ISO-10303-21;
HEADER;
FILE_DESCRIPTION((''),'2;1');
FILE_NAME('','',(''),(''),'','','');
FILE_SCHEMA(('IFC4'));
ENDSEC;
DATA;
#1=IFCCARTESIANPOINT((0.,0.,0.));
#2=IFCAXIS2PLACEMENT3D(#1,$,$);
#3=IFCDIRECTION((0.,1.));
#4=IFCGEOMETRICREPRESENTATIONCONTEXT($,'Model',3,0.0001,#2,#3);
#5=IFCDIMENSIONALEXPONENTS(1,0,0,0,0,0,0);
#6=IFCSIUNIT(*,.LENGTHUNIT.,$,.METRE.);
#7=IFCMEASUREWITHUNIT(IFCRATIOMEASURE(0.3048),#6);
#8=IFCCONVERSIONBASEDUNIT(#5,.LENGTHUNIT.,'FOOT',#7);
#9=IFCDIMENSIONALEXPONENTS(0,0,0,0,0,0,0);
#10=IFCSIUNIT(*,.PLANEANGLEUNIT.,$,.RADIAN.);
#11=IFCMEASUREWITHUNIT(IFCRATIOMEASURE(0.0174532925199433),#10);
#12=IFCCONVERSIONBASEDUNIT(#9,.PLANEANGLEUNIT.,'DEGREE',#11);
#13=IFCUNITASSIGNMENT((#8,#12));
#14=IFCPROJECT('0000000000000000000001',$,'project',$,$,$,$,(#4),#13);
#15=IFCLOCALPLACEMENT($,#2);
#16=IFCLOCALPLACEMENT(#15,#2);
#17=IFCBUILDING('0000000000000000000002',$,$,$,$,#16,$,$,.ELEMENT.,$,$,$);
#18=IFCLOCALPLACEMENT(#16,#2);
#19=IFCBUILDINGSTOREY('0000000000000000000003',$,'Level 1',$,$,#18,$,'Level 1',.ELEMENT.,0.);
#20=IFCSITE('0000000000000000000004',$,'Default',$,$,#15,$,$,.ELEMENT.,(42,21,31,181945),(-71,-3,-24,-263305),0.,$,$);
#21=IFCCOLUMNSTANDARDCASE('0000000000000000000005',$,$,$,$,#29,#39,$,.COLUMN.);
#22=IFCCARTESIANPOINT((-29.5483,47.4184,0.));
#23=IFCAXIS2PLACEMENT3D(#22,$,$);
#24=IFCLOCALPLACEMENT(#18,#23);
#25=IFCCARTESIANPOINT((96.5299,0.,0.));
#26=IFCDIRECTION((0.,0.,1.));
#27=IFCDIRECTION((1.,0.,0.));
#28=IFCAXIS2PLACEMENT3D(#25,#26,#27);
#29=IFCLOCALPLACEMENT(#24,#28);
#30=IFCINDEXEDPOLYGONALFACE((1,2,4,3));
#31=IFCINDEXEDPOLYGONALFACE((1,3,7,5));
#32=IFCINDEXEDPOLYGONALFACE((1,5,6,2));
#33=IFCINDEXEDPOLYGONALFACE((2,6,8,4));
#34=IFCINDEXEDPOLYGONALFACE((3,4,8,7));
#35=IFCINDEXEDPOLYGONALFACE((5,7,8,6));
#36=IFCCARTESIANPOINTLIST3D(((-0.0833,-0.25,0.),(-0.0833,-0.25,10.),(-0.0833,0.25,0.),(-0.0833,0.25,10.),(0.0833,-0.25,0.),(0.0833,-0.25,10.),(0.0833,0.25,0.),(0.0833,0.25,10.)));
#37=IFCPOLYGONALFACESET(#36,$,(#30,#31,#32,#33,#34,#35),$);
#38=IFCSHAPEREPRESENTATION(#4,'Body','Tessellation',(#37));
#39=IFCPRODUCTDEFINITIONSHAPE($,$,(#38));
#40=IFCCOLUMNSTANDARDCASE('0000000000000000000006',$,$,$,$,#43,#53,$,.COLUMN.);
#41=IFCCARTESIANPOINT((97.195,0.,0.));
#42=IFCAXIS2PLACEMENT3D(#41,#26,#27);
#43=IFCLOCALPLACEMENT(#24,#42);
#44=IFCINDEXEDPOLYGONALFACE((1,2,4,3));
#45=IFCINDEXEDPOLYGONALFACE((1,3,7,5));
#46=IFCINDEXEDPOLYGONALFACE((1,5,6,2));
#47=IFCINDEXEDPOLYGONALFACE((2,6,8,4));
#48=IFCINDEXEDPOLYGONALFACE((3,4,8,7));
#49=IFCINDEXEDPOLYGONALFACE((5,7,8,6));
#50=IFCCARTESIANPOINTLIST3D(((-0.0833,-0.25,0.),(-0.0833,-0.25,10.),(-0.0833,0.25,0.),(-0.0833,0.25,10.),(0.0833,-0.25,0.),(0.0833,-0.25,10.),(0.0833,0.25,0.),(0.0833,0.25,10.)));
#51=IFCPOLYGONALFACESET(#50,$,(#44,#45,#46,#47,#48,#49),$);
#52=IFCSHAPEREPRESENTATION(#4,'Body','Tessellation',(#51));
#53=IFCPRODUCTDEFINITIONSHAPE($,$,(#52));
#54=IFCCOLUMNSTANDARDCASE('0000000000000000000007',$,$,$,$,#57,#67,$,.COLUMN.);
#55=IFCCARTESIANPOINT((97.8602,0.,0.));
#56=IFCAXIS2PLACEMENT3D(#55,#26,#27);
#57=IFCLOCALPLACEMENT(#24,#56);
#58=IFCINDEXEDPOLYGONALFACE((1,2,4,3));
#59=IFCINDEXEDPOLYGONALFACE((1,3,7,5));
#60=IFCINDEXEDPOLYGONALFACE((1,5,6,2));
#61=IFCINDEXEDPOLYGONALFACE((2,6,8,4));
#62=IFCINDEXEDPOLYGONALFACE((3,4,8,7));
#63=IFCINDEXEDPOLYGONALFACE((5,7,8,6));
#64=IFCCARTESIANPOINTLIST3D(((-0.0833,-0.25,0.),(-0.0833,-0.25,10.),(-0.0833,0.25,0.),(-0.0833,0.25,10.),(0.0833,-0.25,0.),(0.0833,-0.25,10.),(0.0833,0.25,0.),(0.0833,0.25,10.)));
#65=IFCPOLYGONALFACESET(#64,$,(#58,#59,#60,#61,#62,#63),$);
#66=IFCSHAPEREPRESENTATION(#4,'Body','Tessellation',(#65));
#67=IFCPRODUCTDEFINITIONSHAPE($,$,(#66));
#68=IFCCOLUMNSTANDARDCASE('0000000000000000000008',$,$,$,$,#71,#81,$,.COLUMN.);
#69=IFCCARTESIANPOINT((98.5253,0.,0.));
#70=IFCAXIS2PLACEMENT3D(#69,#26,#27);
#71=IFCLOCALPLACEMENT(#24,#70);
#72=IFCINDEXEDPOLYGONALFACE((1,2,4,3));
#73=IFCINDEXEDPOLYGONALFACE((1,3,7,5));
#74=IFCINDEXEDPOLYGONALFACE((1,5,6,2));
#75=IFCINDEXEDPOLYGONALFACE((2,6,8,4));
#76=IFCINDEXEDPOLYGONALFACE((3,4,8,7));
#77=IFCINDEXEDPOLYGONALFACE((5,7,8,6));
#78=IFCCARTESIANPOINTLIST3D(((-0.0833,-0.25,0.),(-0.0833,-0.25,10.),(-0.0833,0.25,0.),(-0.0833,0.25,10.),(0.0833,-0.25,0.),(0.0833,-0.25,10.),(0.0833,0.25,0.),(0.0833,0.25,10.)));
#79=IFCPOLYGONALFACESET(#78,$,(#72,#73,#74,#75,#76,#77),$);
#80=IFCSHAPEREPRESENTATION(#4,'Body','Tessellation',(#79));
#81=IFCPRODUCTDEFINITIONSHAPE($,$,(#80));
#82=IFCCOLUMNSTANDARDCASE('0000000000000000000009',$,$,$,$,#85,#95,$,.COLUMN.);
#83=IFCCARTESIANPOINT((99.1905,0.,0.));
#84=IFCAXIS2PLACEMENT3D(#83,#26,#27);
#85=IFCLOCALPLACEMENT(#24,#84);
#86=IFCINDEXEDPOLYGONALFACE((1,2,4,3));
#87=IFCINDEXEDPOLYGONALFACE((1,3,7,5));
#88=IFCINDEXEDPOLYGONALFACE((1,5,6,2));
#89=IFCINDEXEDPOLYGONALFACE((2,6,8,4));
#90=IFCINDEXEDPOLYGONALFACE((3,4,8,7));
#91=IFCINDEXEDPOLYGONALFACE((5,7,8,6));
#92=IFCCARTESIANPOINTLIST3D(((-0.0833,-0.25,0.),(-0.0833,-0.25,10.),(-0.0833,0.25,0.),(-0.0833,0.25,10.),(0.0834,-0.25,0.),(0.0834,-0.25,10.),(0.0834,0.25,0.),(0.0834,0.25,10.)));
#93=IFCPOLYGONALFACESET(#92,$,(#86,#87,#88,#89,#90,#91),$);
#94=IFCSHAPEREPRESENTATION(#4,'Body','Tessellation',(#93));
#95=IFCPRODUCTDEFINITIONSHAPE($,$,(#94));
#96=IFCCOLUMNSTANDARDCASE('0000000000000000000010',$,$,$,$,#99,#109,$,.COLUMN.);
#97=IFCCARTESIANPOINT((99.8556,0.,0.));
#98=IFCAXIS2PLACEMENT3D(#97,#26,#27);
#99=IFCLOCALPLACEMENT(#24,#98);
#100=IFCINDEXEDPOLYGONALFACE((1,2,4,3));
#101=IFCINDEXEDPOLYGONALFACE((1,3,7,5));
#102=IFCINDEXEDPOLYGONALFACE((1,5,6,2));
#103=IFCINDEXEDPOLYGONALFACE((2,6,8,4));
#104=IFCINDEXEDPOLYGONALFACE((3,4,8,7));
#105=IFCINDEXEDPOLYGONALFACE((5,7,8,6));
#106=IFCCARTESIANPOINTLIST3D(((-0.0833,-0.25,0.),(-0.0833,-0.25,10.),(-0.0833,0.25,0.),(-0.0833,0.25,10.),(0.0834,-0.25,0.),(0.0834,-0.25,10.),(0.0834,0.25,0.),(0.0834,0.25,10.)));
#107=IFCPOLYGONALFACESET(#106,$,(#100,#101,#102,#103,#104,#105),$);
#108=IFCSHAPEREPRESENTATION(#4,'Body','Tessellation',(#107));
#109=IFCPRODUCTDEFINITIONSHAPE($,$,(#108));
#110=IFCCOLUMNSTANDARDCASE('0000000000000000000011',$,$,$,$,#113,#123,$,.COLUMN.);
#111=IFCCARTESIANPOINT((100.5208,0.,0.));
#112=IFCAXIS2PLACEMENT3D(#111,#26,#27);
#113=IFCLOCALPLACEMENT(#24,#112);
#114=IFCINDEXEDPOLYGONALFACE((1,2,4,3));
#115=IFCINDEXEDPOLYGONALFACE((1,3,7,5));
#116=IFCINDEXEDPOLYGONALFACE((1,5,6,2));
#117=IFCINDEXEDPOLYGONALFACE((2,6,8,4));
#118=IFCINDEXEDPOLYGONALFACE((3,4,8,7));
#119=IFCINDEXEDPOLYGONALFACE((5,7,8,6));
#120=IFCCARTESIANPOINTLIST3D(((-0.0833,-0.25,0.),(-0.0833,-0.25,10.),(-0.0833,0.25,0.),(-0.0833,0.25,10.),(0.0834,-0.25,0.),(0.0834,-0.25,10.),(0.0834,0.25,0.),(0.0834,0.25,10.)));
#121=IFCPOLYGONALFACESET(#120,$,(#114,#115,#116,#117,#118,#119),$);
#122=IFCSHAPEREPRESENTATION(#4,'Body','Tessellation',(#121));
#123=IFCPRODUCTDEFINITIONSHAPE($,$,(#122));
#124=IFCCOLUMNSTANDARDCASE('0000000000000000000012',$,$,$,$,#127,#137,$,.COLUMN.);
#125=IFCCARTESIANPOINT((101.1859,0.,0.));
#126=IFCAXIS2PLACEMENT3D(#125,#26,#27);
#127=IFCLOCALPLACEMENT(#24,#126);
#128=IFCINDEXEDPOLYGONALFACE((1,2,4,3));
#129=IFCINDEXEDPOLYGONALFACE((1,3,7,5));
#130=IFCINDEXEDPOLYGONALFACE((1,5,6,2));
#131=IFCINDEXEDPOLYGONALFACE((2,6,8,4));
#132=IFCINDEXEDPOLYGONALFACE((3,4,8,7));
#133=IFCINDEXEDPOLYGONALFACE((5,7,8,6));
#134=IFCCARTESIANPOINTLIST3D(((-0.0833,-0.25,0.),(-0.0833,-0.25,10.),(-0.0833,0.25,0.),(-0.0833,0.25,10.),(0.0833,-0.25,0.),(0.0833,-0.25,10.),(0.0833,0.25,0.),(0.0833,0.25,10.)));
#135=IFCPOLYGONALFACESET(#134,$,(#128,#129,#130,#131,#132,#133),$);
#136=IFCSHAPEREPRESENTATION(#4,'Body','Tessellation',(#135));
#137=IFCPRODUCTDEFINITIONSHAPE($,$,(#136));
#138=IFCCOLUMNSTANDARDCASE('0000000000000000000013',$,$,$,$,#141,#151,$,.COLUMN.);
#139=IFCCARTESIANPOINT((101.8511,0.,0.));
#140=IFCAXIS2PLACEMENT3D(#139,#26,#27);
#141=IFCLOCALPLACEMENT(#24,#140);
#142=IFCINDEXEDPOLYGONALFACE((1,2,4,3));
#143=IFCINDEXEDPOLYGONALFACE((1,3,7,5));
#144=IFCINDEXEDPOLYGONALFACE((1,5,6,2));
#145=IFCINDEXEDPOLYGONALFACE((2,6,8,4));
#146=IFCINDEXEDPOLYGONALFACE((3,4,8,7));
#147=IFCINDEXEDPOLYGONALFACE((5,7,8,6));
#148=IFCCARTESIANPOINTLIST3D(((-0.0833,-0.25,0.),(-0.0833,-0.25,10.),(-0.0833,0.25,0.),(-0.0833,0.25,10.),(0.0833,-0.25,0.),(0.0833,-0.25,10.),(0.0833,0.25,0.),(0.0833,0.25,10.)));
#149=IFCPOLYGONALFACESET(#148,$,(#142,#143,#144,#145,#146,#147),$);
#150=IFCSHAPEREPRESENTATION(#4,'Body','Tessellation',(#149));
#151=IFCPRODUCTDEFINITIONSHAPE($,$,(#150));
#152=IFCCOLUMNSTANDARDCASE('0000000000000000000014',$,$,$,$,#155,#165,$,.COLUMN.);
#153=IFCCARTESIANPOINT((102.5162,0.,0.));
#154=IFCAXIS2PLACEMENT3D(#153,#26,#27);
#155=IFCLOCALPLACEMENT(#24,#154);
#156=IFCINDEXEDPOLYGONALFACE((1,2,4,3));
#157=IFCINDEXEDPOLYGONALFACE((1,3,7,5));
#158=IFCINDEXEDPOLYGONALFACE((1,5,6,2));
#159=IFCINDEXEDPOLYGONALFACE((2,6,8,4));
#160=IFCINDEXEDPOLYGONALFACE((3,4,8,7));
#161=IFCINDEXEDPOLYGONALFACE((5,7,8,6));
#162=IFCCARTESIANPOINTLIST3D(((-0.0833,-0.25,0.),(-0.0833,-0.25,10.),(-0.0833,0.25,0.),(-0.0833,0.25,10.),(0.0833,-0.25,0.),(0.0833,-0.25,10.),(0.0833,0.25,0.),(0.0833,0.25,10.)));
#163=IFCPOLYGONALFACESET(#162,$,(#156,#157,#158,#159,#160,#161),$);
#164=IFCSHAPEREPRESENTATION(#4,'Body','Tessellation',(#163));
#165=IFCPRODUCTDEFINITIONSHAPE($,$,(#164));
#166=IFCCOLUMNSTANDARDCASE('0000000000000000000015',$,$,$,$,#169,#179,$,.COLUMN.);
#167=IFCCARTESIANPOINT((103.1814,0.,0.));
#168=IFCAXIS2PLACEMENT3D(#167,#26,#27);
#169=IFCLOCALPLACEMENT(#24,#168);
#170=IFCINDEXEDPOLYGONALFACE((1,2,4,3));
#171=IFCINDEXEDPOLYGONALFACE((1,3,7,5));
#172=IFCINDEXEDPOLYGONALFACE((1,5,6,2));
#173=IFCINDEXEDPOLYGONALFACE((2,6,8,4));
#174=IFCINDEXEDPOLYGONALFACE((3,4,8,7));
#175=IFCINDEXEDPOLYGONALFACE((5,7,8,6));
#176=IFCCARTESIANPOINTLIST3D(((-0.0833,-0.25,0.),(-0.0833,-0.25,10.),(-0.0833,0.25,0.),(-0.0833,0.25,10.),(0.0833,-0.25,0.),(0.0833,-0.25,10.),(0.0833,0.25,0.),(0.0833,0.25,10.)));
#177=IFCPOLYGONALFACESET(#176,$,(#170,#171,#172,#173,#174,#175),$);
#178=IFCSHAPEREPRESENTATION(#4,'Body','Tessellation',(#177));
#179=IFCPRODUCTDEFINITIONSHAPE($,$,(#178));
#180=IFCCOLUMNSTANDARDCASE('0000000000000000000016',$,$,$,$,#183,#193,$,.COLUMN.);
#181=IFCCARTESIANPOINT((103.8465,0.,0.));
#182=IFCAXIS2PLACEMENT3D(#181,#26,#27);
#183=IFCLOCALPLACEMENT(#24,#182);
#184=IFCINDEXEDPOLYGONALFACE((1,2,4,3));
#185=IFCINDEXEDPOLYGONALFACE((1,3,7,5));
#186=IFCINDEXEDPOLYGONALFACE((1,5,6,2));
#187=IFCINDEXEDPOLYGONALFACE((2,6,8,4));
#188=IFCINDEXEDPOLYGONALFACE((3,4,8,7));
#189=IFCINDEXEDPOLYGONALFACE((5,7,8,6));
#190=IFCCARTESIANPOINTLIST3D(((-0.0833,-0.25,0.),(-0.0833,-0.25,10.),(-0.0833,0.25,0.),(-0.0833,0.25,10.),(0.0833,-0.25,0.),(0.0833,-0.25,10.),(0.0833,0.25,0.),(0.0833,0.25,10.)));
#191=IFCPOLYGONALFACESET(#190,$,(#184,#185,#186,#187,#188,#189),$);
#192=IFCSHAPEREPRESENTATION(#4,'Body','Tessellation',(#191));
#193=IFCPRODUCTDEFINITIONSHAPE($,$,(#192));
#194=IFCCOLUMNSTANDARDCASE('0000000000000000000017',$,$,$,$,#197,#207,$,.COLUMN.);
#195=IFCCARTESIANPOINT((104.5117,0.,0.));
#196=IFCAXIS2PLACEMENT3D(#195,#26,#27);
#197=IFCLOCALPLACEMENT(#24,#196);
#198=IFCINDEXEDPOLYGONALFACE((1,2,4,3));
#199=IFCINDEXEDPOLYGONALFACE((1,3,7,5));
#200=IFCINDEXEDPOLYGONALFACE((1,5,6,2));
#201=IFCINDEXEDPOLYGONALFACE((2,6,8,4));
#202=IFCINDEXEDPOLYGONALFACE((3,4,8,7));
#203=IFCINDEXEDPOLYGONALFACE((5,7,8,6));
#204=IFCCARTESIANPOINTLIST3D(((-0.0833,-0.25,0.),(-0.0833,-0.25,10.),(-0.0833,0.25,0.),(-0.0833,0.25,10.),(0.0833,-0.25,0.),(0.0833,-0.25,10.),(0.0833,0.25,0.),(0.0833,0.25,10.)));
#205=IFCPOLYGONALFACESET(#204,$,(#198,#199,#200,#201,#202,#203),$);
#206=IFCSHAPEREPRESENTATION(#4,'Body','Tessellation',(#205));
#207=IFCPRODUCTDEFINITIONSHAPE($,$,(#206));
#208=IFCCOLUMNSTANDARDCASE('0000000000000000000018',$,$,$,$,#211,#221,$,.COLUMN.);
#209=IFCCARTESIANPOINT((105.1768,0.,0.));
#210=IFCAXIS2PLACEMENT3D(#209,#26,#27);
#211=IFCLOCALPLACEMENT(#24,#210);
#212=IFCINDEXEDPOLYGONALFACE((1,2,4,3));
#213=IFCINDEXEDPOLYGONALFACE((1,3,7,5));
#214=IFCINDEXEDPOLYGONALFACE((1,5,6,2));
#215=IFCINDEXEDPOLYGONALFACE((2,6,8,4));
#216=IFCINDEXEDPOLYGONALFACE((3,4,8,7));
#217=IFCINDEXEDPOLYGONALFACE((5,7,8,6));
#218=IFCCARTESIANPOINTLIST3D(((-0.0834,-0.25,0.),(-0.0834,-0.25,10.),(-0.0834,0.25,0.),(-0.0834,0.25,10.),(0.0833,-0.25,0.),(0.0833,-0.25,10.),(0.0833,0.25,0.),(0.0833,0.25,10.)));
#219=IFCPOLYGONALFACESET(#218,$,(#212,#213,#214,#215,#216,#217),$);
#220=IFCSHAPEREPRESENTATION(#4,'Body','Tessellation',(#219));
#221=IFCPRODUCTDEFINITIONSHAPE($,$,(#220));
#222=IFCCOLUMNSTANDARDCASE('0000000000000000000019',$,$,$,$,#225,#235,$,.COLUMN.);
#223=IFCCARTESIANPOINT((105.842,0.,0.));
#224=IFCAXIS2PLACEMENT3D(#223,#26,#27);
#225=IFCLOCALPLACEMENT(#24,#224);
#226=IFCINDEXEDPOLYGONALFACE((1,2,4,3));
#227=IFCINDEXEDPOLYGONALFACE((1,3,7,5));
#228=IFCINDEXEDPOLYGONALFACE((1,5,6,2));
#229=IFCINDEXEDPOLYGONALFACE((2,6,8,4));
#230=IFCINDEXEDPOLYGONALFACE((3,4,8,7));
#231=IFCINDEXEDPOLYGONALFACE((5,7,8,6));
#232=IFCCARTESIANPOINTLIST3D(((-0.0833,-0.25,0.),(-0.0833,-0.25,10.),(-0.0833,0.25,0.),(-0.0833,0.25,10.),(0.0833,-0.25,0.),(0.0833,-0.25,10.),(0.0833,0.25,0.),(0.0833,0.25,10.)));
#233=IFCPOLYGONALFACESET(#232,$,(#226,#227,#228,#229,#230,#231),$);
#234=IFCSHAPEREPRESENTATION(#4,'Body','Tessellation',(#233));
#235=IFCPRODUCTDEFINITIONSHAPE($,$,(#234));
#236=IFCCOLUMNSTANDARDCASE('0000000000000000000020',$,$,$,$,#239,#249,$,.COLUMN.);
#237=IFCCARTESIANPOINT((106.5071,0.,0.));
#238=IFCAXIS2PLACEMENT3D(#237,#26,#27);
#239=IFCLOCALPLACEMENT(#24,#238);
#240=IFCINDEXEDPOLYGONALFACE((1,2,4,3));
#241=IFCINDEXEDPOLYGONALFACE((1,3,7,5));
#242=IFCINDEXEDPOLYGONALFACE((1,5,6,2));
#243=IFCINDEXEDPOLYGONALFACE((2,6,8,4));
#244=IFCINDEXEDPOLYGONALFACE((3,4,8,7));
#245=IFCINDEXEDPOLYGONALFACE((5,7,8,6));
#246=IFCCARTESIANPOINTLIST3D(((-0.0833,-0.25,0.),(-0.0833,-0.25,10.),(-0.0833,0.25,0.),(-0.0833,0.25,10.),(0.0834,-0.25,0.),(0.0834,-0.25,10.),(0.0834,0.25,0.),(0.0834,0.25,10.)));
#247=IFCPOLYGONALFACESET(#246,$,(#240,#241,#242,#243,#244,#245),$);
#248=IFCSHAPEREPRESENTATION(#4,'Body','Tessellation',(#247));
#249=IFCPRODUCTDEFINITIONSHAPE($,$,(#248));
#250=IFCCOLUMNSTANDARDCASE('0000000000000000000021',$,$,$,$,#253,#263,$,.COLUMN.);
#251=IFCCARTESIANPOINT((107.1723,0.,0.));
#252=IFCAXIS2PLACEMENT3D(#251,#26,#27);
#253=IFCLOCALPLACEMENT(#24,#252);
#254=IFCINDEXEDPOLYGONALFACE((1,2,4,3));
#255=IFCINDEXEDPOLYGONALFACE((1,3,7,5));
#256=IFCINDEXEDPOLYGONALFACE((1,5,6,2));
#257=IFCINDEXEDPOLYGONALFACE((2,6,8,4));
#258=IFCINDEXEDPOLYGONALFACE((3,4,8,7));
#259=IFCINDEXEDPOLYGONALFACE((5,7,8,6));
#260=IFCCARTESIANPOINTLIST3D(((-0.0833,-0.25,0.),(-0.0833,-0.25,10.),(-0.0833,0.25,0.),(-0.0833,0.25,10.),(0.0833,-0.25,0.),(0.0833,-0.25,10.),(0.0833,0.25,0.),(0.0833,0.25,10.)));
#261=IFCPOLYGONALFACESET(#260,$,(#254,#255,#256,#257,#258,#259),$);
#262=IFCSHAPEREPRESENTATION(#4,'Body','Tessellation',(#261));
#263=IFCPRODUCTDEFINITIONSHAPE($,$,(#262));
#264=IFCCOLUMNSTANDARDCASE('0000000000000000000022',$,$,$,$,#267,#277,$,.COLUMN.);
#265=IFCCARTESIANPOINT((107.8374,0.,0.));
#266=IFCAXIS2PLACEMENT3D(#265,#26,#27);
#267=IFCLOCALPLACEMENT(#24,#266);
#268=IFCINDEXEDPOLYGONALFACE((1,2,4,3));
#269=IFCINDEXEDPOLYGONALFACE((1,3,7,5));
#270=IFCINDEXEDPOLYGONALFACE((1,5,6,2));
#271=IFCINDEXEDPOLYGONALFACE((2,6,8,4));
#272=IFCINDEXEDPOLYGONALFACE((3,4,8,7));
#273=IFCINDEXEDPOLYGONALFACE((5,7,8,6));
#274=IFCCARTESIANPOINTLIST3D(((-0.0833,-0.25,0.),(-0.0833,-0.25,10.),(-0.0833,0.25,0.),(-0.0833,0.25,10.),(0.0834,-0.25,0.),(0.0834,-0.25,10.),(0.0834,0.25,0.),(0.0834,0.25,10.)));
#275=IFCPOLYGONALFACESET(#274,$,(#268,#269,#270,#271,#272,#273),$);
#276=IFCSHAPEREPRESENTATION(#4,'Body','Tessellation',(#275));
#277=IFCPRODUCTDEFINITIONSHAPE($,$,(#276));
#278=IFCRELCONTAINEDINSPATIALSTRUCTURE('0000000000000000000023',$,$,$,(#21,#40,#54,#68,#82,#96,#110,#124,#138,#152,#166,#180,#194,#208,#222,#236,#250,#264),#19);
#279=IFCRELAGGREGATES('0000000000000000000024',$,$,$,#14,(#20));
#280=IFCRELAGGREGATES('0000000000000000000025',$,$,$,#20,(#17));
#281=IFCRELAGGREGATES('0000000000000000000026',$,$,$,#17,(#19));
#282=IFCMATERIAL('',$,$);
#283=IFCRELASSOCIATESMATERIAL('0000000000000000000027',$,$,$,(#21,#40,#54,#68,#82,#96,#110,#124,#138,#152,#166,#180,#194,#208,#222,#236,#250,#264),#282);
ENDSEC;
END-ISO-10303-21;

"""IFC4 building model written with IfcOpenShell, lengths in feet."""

from ifc_helpers import new_model, entity, si_unit, converted_unit, direction, frame, origin, place, context, project, spatial, rectangle, extrude, material, element, save


model = new_model("IFC4")

# Units and contexts
model_context = context("Model", 3, precision=0.0001, world=origin(), true_north=direction((0.0, 1.0)))
ifc_project = project(units=[converted_unit("LENGTHUNIT", "FOOT", entity("IfcRatioMeasure", 0.3048), si_unit("LENGTHUNIT", "METRE"), dimensions=[1, 0, 0, 0, 0, 0, 0]), converted_unit("PLANEANGLEUNIT", "DEGREE", entity("IfcRatioMeasure", 0.0174532925199433), si_unit("PLANEANGLEUNIT", "RADIAN"), dimensions=[0, 0, 0, 0, 0, 0, 0])], contexts=[model_context])

# Site, building, storey
site_placement = place(None, origin())
site = spatial("IfcSite", under=ifc_project, at=site_placement, Name="Default", CompositionType="ELEMENT", RefLatitude=(42, 21, 31, 181945), RefLongitude=(-71, -3, -24, -263305), RefElevation=0.0)
building_placement = place(site_placement, origin())
building = spatial("IfcBuilding", under=site, at=building_placement, CompositionType="ELEMENT")
storey_placement = place(building_placement, origin())
storey = spatial("IfcBuildingStorey", under=building, at=storey_placement, Name="Level 1", LongName="Level 1", CompositionType="ELEMENT", Elevation=0.0)

# Columns
ifc_material = material(Name="")
placement = place(storey_placement, frame((-29.5483, 47.4184, 0.0)))
for number, where, z_axis, x_axis in (
    (1, (96.5299, 0.0, 0.0), (0.0, 0.0, 1.0), (1.0, 0.0, 0.0)),
    (2, (97.195, 0.0, 0.0), (0.0, 0.0, 1.0), (1.0, 0.0, 0.0)),
    (3, (97.8602, 0.0, 0.0), (0.0, 0.0, 1.0), (1.0, 0.0, 0.0)),
    (4, (98.5253, 0.0, 0.0), (0.0, 0.0, 1.0), (1.0, 0.0, 0.0)),
    (5, (99.1905, 0.0, 0.0), (0.0, 0.0, 1.0), (1.0, 0.0, 0.0)),
    (6, (99.8556, 0.0, 0.0), (0.0, 0.0, 1.0), (1.0, 0.0, 0.0)),
    (7, (100.5208, 0.0, 0.0), (0.0, 0.0, 1.0), (1.0, 0.0, 0.0)),
    (8, (101.1859, 0.0, 0.0), (0.0, 0.0, 1.0), (1.0, 0.0, 0.0)),
    (9, (101.8511, 0.0, 0.0), (0.0, 0.0, 1.0), (1.0, 0.0, 0.0)),
    (10, (102.5162, 0.0, 0.0), (0.0, 0.0, 1.0), (1.0, 0.0, 0.0)),
    (11, (103.1814, 0.0, 0.0), (0.0, 0.0, 1.0), (1.0, 0.0, 0.0)),
    (12, (103.8465, 0.0, 0.0), (0.0, 0.0, 1.0), (1.0, 0.0, 0.0)),
    (13, (104.5117, 0.0, 0.0), (0.0, 0.0, 1.0), (1.0, 0.0, 0.0)),
    (14, (105.1768, 0.0, 0.0), (0.0, 0.0, 1.0), (1.0, 0.0, 0.0)),
    (15, (105.842, 0.0, 0.0), (0.0, 0.0, 1.0), (1.0, 0.0, 0.0)),
    (16, (106.5071, 0.0, 0.0), (0.0, 0.0, 1.0), (1.0, 0.0, 0.0)),
    (17, (107.1723, 0.0, 0.0), (0.0, 0.0, 1.0), (1.0, 0.0, 0.0)),
    (18, (107.8374, 0.0, 0.0), (0.0, 0.0, 1.0), (1.0, 0.0, 0.0)),
):
    element("IfcColumnStandardCase", number, at=place(placement, frame(where, z_axis=z_axis, x_axis=x_axis)), inside=storey, material=ifc_material, PredefinedType="COLUMN", context=model_context, shape_type="SweptSolid", body=[
        extrude(rectangle(XDim=0.1667, YDim=0.5), origin(), (0.0, 0.0, 1.0), 10.0),
    ])

save(model, "model.ifc")
